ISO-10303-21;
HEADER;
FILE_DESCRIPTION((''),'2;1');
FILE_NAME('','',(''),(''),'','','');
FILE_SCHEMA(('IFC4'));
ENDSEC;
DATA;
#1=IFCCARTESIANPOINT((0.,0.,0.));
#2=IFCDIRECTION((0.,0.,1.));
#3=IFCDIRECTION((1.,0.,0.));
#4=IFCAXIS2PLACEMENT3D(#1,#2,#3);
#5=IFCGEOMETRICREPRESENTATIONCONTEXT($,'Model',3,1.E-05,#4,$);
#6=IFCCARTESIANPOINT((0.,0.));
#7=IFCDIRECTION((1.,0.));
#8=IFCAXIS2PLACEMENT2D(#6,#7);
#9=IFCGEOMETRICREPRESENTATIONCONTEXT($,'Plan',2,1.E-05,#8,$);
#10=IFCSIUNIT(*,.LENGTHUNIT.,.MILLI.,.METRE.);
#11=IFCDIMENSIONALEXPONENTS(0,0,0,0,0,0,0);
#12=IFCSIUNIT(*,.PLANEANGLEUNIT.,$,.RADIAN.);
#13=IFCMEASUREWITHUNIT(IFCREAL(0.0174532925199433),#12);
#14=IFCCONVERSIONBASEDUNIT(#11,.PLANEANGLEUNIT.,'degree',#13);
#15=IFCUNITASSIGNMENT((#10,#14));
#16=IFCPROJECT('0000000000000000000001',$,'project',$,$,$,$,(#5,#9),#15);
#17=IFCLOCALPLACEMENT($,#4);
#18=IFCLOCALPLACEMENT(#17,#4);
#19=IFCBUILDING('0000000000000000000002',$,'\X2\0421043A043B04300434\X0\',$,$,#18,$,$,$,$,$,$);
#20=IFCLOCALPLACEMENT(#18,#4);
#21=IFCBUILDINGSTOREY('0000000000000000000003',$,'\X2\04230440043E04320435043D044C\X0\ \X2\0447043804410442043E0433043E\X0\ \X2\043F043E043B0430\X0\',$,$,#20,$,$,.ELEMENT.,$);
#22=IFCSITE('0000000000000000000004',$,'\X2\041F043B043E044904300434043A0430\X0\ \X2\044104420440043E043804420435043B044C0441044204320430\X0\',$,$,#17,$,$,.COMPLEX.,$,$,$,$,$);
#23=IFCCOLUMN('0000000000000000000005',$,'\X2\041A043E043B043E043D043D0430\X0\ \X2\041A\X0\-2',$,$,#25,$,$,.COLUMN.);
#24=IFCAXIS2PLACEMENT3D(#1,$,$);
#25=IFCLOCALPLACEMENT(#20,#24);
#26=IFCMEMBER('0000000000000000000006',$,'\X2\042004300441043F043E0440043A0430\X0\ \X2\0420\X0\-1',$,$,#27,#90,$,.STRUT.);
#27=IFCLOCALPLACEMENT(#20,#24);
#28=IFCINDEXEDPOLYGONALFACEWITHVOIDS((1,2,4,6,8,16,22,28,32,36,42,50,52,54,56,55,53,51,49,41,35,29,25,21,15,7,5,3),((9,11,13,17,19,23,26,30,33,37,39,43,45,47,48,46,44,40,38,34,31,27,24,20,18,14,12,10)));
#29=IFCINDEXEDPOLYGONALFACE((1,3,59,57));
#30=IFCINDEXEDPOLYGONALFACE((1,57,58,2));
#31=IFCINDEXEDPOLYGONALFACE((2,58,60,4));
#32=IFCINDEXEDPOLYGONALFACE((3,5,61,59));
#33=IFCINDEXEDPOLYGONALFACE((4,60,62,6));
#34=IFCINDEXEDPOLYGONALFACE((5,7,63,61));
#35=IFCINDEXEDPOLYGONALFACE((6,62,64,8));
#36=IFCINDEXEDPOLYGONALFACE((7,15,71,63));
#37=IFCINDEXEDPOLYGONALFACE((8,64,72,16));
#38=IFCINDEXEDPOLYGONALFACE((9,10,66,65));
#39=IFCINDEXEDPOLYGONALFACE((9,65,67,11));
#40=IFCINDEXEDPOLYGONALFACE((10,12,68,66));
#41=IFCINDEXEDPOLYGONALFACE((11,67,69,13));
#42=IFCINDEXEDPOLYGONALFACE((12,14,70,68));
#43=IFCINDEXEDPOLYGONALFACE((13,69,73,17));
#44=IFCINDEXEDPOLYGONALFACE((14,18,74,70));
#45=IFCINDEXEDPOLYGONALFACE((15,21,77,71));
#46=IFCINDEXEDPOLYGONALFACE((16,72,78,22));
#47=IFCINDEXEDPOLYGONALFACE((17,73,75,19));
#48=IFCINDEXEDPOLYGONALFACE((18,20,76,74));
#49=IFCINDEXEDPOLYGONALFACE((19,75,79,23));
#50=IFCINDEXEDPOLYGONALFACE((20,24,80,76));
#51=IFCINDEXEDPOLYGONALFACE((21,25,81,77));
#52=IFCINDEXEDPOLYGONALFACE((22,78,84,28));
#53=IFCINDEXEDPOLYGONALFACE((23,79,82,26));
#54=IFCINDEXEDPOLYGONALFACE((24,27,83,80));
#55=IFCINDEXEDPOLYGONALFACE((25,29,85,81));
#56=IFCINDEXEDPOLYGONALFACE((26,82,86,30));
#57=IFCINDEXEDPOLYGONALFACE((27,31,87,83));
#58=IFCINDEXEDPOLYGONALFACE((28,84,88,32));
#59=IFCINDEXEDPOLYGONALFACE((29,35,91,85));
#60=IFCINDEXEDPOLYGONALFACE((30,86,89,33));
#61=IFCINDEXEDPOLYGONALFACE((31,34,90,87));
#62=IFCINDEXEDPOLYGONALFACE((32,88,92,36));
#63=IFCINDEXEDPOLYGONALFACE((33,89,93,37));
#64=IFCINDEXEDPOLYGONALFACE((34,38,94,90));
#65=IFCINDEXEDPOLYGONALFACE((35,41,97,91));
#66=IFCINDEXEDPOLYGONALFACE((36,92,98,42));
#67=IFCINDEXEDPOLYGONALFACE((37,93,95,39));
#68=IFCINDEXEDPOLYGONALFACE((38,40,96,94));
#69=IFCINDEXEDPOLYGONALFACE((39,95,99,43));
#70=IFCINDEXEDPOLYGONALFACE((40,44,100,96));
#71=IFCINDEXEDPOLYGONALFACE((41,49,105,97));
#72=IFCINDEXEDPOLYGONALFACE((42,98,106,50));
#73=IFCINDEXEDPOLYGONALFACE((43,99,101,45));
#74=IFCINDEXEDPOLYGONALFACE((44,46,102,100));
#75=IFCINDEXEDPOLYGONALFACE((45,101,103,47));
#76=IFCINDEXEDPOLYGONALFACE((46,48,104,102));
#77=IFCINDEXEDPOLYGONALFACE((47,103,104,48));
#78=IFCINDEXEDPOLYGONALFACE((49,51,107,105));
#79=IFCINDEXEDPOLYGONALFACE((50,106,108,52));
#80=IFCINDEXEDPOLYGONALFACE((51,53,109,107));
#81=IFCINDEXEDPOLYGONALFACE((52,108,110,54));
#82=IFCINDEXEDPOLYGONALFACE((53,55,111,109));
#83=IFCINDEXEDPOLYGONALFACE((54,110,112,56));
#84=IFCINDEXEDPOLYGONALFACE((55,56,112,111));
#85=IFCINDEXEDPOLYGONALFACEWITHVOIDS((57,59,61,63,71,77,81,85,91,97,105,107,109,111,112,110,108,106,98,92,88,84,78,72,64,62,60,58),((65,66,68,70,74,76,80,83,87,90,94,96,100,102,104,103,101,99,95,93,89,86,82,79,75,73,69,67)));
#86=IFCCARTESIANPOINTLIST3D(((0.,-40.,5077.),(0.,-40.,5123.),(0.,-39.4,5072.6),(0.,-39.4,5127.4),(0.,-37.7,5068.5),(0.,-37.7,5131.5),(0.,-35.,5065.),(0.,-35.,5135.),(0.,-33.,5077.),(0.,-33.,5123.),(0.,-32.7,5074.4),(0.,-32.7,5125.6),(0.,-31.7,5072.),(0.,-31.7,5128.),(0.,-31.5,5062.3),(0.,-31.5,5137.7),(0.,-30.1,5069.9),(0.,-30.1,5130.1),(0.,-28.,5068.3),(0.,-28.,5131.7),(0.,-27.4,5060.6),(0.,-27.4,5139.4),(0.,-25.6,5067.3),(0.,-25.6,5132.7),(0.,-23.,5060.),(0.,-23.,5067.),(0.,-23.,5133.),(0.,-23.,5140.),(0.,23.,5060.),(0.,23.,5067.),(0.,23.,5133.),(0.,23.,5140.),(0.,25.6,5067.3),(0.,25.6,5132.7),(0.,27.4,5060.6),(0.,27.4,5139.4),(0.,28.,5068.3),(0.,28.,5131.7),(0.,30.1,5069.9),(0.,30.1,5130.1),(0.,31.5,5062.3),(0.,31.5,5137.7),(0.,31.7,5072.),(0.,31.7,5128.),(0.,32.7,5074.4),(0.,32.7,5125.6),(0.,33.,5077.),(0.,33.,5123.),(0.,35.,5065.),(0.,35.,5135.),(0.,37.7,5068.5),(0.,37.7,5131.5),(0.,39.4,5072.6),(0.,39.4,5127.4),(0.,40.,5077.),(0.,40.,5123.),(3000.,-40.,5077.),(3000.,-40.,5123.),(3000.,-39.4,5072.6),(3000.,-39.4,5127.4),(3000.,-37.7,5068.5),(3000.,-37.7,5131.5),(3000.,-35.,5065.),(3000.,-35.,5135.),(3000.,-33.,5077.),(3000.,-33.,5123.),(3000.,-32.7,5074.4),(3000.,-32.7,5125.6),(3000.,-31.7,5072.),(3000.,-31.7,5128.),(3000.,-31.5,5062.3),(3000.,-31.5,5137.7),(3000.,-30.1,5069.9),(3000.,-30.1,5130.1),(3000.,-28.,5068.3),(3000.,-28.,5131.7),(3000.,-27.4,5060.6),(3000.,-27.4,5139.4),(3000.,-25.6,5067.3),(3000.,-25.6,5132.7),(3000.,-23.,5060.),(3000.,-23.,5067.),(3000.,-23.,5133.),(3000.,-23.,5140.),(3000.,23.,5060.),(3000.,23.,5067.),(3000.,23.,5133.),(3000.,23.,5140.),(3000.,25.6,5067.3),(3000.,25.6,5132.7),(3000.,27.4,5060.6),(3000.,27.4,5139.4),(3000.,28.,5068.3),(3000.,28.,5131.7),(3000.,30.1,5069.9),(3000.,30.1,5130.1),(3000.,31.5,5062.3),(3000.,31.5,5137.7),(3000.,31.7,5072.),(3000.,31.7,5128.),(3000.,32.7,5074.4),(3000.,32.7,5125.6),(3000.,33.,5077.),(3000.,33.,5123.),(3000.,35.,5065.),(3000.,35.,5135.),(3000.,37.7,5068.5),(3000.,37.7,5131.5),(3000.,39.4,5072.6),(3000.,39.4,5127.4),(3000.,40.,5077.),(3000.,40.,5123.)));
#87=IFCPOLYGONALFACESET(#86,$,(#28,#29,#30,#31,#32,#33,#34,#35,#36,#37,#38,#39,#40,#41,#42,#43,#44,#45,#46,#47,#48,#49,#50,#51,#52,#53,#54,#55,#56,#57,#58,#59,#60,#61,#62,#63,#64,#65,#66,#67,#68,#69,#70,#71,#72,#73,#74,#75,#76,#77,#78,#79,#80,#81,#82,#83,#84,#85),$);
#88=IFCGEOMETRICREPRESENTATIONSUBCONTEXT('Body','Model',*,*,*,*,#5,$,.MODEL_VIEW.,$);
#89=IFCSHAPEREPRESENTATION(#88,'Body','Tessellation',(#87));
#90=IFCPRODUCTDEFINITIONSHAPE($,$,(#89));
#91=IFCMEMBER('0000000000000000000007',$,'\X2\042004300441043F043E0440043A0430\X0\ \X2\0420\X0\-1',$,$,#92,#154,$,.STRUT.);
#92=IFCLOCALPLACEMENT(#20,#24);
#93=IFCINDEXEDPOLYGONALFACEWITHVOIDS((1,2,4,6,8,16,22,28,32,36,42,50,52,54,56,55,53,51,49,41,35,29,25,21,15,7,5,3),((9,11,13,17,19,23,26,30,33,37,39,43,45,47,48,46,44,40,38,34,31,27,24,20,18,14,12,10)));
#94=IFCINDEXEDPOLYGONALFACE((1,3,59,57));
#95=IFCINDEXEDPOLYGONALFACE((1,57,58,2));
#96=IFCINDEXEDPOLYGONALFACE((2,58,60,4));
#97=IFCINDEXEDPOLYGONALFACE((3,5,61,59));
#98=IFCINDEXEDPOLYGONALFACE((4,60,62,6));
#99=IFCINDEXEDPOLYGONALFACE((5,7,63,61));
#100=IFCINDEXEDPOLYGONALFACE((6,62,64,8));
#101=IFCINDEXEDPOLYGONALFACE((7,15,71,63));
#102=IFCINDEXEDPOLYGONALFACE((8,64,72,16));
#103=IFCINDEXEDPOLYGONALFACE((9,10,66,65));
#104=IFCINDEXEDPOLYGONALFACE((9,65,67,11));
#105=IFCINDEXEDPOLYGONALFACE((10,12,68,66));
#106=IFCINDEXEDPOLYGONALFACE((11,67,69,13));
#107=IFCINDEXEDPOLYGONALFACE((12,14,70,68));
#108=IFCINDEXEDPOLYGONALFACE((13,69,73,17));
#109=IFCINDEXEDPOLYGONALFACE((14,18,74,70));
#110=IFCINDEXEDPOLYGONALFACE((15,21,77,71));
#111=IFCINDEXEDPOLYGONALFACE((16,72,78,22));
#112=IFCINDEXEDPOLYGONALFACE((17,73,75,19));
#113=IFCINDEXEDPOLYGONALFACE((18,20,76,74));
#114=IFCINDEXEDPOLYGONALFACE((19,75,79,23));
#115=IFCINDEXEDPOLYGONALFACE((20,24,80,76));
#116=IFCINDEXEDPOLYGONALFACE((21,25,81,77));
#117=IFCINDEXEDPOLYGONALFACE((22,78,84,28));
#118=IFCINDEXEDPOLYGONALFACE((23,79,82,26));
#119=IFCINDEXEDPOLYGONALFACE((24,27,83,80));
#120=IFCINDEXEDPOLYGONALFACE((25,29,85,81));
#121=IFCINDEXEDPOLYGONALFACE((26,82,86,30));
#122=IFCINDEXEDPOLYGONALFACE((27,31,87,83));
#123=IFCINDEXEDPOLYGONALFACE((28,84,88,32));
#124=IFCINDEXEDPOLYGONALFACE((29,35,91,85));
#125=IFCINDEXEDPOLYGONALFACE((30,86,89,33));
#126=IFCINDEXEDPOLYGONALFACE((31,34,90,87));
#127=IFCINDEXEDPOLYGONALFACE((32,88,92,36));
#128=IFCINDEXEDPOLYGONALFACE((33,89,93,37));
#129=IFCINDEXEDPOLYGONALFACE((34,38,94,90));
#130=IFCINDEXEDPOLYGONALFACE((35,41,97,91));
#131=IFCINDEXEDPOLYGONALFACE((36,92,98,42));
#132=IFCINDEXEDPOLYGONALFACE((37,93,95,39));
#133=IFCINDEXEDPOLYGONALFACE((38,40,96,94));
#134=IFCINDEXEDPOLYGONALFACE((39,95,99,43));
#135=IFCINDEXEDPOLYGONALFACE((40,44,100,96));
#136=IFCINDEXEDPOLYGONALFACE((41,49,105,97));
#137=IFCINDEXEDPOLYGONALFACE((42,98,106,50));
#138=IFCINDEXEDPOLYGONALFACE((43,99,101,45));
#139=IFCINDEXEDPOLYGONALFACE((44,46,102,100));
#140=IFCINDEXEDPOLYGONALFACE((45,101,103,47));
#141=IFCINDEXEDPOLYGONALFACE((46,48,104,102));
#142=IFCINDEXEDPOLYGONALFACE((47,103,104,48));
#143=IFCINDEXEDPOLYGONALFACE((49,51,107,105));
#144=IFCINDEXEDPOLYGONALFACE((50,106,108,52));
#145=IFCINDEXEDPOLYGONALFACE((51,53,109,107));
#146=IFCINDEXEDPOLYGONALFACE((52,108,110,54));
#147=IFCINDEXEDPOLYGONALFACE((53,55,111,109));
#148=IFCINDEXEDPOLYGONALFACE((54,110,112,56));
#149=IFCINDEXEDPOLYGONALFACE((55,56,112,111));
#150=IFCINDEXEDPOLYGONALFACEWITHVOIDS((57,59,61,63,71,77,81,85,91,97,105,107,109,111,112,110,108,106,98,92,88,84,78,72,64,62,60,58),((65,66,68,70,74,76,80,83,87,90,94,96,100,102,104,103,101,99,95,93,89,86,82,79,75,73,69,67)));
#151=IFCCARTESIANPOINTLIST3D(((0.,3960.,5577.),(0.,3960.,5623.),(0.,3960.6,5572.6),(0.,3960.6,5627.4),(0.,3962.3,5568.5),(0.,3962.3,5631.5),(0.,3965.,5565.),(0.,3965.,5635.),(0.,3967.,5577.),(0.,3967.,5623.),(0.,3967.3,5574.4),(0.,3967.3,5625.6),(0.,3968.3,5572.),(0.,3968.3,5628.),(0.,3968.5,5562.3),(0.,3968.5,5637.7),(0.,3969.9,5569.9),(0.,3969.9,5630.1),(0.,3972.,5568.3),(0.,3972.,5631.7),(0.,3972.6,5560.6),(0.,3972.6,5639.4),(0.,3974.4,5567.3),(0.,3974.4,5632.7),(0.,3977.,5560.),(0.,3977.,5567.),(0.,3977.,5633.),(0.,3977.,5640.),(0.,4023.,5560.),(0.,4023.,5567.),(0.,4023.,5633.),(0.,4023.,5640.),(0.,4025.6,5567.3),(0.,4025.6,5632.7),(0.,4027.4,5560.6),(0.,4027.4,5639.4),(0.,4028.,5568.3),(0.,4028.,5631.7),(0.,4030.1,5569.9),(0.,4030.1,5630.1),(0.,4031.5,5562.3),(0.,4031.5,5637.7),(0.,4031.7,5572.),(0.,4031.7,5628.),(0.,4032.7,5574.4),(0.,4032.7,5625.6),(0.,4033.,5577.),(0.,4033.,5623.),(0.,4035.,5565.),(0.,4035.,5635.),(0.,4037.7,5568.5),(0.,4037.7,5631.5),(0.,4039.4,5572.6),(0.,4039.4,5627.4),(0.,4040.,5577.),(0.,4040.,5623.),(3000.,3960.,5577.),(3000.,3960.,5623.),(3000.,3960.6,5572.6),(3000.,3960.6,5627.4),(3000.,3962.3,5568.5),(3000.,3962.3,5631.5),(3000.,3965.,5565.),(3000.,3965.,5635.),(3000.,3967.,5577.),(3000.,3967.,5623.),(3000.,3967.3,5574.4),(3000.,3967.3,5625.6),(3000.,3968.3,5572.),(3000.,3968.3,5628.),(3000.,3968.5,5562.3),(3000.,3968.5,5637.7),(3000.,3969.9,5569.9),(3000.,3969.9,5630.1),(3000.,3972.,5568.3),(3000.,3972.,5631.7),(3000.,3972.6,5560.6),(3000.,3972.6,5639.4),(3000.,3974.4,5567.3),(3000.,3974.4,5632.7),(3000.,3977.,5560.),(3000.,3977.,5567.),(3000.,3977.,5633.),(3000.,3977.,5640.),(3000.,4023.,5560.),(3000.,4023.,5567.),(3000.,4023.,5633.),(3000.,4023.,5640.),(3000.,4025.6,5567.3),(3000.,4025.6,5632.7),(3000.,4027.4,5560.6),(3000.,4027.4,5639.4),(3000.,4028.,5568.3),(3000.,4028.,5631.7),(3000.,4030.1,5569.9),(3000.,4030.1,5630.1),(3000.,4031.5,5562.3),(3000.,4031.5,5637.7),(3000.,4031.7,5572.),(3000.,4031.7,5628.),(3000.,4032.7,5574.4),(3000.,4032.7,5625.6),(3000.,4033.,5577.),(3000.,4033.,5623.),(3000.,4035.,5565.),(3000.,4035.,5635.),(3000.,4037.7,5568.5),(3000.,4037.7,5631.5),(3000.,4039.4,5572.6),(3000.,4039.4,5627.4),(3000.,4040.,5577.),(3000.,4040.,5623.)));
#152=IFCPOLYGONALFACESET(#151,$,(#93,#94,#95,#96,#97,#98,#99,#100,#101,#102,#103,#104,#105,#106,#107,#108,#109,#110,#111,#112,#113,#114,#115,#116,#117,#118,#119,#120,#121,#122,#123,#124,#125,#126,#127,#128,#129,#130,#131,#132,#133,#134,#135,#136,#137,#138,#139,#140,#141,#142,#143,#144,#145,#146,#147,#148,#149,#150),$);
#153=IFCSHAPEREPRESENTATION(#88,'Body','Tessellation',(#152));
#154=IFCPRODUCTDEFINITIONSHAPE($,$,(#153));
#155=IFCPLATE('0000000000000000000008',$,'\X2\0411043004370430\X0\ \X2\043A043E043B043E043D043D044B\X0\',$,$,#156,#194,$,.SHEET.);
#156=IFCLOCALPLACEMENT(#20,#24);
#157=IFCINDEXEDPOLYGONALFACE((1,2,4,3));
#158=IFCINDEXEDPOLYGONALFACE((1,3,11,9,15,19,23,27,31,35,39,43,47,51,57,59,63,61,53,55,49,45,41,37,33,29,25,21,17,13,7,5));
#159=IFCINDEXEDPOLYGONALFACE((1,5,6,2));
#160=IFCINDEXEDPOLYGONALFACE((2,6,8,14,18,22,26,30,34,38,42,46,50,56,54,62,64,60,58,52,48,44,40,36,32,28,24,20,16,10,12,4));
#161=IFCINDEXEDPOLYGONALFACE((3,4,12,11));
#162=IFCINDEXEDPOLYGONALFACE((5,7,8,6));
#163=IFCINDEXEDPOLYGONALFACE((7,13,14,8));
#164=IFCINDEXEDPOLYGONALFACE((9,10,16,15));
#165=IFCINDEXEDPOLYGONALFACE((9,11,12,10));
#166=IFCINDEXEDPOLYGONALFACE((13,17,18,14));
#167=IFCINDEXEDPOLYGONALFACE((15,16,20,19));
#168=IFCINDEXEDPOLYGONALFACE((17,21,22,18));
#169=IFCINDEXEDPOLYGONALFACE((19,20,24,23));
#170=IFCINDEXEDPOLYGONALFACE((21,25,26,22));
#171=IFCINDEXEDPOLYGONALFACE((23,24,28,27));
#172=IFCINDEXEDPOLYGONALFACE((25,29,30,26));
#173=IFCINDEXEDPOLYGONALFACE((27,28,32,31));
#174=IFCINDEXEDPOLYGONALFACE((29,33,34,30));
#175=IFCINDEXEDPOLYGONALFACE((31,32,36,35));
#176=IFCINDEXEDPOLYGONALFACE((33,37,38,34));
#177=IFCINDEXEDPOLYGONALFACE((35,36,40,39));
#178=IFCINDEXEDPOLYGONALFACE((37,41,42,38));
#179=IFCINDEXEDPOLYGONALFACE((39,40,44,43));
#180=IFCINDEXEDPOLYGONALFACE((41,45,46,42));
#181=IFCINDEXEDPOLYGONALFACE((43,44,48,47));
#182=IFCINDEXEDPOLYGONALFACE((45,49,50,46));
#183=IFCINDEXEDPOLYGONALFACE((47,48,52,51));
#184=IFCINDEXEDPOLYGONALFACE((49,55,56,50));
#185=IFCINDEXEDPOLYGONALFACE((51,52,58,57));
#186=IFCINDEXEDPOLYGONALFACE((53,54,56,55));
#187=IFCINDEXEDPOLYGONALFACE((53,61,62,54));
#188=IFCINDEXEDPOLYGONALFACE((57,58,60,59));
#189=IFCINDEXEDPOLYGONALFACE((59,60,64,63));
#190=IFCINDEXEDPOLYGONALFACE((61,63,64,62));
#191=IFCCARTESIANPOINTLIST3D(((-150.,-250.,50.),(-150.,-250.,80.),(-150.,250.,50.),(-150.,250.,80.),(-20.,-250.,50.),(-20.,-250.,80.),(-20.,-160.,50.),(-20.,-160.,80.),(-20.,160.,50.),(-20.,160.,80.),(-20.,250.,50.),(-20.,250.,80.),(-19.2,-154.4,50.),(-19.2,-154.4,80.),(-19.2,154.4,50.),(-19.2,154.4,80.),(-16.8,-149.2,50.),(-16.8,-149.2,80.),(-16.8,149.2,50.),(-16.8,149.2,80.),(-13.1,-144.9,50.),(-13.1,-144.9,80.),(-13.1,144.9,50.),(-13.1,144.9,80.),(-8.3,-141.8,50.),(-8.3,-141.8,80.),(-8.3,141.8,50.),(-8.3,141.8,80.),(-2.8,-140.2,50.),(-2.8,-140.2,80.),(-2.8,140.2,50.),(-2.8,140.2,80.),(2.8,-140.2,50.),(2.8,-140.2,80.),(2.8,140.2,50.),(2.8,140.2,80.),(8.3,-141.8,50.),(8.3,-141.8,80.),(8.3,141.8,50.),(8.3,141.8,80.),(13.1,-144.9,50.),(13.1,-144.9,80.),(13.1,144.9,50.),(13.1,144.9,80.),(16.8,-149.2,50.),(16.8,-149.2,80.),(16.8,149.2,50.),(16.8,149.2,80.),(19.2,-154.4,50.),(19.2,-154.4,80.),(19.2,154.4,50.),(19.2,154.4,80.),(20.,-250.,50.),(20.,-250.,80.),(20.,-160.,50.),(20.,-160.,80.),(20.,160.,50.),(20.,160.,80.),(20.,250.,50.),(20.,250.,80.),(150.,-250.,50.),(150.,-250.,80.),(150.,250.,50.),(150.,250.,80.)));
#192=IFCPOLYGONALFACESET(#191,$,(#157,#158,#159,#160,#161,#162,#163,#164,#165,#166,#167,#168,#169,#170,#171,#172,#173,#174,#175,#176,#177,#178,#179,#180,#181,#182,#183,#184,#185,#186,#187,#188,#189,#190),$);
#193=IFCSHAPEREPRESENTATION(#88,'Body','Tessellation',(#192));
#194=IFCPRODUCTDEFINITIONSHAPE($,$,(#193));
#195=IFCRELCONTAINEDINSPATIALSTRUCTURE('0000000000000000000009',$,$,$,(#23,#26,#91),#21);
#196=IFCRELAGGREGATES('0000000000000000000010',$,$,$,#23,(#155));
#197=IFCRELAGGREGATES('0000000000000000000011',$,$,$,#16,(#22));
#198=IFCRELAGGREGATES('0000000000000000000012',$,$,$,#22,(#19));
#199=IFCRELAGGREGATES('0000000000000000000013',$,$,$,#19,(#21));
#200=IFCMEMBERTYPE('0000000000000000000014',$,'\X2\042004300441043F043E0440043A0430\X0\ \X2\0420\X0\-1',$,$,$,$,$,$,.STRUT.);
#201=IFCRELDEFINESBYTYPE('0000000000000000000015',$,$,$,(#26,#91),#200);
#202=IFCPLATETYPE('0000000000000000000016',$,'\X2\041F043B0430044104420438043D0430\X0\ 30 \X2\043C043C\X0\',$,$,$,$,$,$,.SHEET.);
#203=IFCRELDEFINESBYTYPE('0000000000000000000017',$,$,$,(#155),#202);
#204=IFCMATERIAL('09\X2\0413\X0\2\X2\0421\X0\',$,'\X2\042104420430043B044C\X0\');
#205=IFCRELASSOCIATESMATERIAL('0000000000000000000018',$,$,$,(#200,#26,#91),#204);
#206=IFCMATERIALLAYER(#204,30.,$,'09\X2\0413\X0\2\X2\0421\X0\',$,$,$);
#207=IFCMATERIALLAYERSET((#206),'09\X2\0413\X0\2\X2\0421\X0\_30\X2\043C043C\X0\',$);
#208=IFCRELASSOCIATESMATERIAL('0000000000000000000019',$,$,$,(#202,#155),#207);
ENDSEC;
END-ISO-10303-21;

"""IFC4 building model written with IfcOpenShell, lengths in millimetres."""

from ifc_helpers import new_model, entity, si_unit, converted_unit, frame, origin_with_axes, origin_2d_with_axis, place, context, subcontext, project, spatial, line, arc, indexed_curve, hollow_rectangle, outline, extrude, material, layer, layer_set, layer_usage, material_profile, profile_set, profile_usage, type_object, element, aggregate, save


model = new_model("IFC4")

# Units and contexts
model_context = context("Model", 3, precision=1e-05, world=origin_with_axes())
plan_context = context("Plan", 2, precision=1e-05, world=origin_2d_with_axis())
body_context = subcontext(model_context, "Body", "Model", "MODEL_VIEW")
ifc_project = project(units=[si_unit("LENGTHUNIT", "METRE", prefix="MILLI"), converted_unit("PLANEANGLEUNIT", "degree", entity("IfcReal", 0.0174532925199433), si_unit("PLANEANGLEUNIT", "RADIAN"), dimensions=[0, 0, 0, 0, 0, 0, 0])], contexts=[model_context, plan_context])

# Site, building, storey
site_placement = place(None, origin_with_axes())
site = spatial("IfcSite", under=ifc_project, at=site_placement, Name="Площадка строительства", CompositionType="COMPLEX")
building_placement = place(site_placement, origin_with_axes())
building = spatial("IfcBuilding", under=site, at=building_placement, Name="Склад")
storey_placement = place(building_placement, origin_with_axes())
storey = spatial("IfcBuildingStorey", under=building, at=storey_placement, Name="Уровень чистого пола", CompositionType="ELEMENT")

# Column
column_1_placement = place(storey_placement, origin_with_axes())
column_1 = element("IfcColumn", 1, at=column_1_placement, inside=storey, Name="Колонна К-2", PredefinedType="COLUMN")

# Members
ifc_material_1 = material(Name="09Г2С", Category="Сталь")
ifc_material_profile_1 = material_profile(ifc_material_1, hollow_rectangle(XDim=80.0, YDim=80.0, WallThickness=7.0, InnerFilletRadius=10.0, OuterFilletRadius=17.0))
ifc_profile_set_1 = profile_set([ifc_material_profile_1], Name="PK80x7_09G2S")
ifc_profile_usage_1 = profile_usage(ifc_profile_set_1, cardinal=5)
member_type_1 = type_object("IfcMemberType", Name="Распорка Р-1", PredefinedType="STRUT", material=ifc_profile_set_1)
member_1_placement = place(storey_placement, frame((0.0, 0.0, 5100.0), z_axis=(1.0, 0.0, 0.0), x_axis=(0.0, 1.0, 0.0)))
element("IfcMember", 2, at=member_1_placement, inside=storey, type_object=member_type_1, material=ifc_profile_usage_1, Name="Распорка Р-1", PredefinedType="STRUT", context=body_context, shape_type="SweptSolid", body=[
    extrude(hollow_rectangle(XDim=80.0, YDim=80.0, WallThickness=7.0, InnerFilletRadius=10.0, OuterFilletRadius=17.0), origin_with_axes(), (0.0, 0.0, 1.0), 3000.0),
])
ifc_profile_usage_2 = profile_usage(ifc_profile_set_1, cardinal=5)
member_2_placement = place(storey_placement, frame((0.0, 4000.0, 5600.0), z_axis=(1.0, 0.0, 0.0), x_axis=(0.0, 1.0, 0.0)))
element("IfcMember", 3, at=member_2_placement, inside=storey, type_object=member_type_1, material=ifc_profile_usage_2, Name="Распорка Р-1", PredefinedType="STRUT", context=body_context, shape_type="SweptSolid", body=[
    extrude(hollow_rectangle(XDim=80.0, YDim=80.0, WallThickness=7.0, InnerFilletRadius=10.0, OuterFilletRadius=17.0), origin_with_axes(), (0.0, 0.0, 1.0), 3000.0),
])

# Plate
ifc_layer = layer(ifc_material_1, 30.0, Name="09Г2С")
ifc_layer_set = layer_set([ifc_layer], Name="09Г2С_30мм")
ifc_layer_usage = layer_usage(ifc_layer_set, "AXIS3", "POSITIVE", 0.0)
plate_type = type_object("IfcPlateType", Name="Пластина 30 мм", PredefinedType="SHEET", material=ifc_layer_set)
plate_placement = place(column_1_placement, frame((0.0, 0.0, 50.0), z_axis=(0.0, 0.0, 1.0), x_axis=(1.0, 0.0, 0.0)))
plate = element("IfcPlate", 4, at=plate_placement, type_object=plate_type, material=ifc_layer_usage, Name="База колонны", PredefinedType="SHEET", context=body_context, shape_type="SweptSolid", body=[
    extrude(outline(indexed_curve([(-20.0, -250.0), (-150.0, -250.0), (-150.0, 250.0), (150.0, 250.0), (150.0, -250.0), (20.0, -250.0), (20.0, -160.0), (0.0, -140.0), (-20.0, -160.0), (20.0, 250.0), (-20.0, 250.0), (-20.0, 160.0), (0.0, 140.0), (20.0, 160.0)], segments=[line(5, 4), line(4, 10), line(10, 14), arc(14, 13, 12), line(12, 11), line(11, 3), line(3, 2), line(2, 1), line(1, 9), arc(9, 8, 7), line(7, 6), line(6, 5)], self_intersect=False)), None, (0.0, 0.0, 1.0), 30.0),
])

aggregate(column_1, [plate])

save(model, "model.ifc")
